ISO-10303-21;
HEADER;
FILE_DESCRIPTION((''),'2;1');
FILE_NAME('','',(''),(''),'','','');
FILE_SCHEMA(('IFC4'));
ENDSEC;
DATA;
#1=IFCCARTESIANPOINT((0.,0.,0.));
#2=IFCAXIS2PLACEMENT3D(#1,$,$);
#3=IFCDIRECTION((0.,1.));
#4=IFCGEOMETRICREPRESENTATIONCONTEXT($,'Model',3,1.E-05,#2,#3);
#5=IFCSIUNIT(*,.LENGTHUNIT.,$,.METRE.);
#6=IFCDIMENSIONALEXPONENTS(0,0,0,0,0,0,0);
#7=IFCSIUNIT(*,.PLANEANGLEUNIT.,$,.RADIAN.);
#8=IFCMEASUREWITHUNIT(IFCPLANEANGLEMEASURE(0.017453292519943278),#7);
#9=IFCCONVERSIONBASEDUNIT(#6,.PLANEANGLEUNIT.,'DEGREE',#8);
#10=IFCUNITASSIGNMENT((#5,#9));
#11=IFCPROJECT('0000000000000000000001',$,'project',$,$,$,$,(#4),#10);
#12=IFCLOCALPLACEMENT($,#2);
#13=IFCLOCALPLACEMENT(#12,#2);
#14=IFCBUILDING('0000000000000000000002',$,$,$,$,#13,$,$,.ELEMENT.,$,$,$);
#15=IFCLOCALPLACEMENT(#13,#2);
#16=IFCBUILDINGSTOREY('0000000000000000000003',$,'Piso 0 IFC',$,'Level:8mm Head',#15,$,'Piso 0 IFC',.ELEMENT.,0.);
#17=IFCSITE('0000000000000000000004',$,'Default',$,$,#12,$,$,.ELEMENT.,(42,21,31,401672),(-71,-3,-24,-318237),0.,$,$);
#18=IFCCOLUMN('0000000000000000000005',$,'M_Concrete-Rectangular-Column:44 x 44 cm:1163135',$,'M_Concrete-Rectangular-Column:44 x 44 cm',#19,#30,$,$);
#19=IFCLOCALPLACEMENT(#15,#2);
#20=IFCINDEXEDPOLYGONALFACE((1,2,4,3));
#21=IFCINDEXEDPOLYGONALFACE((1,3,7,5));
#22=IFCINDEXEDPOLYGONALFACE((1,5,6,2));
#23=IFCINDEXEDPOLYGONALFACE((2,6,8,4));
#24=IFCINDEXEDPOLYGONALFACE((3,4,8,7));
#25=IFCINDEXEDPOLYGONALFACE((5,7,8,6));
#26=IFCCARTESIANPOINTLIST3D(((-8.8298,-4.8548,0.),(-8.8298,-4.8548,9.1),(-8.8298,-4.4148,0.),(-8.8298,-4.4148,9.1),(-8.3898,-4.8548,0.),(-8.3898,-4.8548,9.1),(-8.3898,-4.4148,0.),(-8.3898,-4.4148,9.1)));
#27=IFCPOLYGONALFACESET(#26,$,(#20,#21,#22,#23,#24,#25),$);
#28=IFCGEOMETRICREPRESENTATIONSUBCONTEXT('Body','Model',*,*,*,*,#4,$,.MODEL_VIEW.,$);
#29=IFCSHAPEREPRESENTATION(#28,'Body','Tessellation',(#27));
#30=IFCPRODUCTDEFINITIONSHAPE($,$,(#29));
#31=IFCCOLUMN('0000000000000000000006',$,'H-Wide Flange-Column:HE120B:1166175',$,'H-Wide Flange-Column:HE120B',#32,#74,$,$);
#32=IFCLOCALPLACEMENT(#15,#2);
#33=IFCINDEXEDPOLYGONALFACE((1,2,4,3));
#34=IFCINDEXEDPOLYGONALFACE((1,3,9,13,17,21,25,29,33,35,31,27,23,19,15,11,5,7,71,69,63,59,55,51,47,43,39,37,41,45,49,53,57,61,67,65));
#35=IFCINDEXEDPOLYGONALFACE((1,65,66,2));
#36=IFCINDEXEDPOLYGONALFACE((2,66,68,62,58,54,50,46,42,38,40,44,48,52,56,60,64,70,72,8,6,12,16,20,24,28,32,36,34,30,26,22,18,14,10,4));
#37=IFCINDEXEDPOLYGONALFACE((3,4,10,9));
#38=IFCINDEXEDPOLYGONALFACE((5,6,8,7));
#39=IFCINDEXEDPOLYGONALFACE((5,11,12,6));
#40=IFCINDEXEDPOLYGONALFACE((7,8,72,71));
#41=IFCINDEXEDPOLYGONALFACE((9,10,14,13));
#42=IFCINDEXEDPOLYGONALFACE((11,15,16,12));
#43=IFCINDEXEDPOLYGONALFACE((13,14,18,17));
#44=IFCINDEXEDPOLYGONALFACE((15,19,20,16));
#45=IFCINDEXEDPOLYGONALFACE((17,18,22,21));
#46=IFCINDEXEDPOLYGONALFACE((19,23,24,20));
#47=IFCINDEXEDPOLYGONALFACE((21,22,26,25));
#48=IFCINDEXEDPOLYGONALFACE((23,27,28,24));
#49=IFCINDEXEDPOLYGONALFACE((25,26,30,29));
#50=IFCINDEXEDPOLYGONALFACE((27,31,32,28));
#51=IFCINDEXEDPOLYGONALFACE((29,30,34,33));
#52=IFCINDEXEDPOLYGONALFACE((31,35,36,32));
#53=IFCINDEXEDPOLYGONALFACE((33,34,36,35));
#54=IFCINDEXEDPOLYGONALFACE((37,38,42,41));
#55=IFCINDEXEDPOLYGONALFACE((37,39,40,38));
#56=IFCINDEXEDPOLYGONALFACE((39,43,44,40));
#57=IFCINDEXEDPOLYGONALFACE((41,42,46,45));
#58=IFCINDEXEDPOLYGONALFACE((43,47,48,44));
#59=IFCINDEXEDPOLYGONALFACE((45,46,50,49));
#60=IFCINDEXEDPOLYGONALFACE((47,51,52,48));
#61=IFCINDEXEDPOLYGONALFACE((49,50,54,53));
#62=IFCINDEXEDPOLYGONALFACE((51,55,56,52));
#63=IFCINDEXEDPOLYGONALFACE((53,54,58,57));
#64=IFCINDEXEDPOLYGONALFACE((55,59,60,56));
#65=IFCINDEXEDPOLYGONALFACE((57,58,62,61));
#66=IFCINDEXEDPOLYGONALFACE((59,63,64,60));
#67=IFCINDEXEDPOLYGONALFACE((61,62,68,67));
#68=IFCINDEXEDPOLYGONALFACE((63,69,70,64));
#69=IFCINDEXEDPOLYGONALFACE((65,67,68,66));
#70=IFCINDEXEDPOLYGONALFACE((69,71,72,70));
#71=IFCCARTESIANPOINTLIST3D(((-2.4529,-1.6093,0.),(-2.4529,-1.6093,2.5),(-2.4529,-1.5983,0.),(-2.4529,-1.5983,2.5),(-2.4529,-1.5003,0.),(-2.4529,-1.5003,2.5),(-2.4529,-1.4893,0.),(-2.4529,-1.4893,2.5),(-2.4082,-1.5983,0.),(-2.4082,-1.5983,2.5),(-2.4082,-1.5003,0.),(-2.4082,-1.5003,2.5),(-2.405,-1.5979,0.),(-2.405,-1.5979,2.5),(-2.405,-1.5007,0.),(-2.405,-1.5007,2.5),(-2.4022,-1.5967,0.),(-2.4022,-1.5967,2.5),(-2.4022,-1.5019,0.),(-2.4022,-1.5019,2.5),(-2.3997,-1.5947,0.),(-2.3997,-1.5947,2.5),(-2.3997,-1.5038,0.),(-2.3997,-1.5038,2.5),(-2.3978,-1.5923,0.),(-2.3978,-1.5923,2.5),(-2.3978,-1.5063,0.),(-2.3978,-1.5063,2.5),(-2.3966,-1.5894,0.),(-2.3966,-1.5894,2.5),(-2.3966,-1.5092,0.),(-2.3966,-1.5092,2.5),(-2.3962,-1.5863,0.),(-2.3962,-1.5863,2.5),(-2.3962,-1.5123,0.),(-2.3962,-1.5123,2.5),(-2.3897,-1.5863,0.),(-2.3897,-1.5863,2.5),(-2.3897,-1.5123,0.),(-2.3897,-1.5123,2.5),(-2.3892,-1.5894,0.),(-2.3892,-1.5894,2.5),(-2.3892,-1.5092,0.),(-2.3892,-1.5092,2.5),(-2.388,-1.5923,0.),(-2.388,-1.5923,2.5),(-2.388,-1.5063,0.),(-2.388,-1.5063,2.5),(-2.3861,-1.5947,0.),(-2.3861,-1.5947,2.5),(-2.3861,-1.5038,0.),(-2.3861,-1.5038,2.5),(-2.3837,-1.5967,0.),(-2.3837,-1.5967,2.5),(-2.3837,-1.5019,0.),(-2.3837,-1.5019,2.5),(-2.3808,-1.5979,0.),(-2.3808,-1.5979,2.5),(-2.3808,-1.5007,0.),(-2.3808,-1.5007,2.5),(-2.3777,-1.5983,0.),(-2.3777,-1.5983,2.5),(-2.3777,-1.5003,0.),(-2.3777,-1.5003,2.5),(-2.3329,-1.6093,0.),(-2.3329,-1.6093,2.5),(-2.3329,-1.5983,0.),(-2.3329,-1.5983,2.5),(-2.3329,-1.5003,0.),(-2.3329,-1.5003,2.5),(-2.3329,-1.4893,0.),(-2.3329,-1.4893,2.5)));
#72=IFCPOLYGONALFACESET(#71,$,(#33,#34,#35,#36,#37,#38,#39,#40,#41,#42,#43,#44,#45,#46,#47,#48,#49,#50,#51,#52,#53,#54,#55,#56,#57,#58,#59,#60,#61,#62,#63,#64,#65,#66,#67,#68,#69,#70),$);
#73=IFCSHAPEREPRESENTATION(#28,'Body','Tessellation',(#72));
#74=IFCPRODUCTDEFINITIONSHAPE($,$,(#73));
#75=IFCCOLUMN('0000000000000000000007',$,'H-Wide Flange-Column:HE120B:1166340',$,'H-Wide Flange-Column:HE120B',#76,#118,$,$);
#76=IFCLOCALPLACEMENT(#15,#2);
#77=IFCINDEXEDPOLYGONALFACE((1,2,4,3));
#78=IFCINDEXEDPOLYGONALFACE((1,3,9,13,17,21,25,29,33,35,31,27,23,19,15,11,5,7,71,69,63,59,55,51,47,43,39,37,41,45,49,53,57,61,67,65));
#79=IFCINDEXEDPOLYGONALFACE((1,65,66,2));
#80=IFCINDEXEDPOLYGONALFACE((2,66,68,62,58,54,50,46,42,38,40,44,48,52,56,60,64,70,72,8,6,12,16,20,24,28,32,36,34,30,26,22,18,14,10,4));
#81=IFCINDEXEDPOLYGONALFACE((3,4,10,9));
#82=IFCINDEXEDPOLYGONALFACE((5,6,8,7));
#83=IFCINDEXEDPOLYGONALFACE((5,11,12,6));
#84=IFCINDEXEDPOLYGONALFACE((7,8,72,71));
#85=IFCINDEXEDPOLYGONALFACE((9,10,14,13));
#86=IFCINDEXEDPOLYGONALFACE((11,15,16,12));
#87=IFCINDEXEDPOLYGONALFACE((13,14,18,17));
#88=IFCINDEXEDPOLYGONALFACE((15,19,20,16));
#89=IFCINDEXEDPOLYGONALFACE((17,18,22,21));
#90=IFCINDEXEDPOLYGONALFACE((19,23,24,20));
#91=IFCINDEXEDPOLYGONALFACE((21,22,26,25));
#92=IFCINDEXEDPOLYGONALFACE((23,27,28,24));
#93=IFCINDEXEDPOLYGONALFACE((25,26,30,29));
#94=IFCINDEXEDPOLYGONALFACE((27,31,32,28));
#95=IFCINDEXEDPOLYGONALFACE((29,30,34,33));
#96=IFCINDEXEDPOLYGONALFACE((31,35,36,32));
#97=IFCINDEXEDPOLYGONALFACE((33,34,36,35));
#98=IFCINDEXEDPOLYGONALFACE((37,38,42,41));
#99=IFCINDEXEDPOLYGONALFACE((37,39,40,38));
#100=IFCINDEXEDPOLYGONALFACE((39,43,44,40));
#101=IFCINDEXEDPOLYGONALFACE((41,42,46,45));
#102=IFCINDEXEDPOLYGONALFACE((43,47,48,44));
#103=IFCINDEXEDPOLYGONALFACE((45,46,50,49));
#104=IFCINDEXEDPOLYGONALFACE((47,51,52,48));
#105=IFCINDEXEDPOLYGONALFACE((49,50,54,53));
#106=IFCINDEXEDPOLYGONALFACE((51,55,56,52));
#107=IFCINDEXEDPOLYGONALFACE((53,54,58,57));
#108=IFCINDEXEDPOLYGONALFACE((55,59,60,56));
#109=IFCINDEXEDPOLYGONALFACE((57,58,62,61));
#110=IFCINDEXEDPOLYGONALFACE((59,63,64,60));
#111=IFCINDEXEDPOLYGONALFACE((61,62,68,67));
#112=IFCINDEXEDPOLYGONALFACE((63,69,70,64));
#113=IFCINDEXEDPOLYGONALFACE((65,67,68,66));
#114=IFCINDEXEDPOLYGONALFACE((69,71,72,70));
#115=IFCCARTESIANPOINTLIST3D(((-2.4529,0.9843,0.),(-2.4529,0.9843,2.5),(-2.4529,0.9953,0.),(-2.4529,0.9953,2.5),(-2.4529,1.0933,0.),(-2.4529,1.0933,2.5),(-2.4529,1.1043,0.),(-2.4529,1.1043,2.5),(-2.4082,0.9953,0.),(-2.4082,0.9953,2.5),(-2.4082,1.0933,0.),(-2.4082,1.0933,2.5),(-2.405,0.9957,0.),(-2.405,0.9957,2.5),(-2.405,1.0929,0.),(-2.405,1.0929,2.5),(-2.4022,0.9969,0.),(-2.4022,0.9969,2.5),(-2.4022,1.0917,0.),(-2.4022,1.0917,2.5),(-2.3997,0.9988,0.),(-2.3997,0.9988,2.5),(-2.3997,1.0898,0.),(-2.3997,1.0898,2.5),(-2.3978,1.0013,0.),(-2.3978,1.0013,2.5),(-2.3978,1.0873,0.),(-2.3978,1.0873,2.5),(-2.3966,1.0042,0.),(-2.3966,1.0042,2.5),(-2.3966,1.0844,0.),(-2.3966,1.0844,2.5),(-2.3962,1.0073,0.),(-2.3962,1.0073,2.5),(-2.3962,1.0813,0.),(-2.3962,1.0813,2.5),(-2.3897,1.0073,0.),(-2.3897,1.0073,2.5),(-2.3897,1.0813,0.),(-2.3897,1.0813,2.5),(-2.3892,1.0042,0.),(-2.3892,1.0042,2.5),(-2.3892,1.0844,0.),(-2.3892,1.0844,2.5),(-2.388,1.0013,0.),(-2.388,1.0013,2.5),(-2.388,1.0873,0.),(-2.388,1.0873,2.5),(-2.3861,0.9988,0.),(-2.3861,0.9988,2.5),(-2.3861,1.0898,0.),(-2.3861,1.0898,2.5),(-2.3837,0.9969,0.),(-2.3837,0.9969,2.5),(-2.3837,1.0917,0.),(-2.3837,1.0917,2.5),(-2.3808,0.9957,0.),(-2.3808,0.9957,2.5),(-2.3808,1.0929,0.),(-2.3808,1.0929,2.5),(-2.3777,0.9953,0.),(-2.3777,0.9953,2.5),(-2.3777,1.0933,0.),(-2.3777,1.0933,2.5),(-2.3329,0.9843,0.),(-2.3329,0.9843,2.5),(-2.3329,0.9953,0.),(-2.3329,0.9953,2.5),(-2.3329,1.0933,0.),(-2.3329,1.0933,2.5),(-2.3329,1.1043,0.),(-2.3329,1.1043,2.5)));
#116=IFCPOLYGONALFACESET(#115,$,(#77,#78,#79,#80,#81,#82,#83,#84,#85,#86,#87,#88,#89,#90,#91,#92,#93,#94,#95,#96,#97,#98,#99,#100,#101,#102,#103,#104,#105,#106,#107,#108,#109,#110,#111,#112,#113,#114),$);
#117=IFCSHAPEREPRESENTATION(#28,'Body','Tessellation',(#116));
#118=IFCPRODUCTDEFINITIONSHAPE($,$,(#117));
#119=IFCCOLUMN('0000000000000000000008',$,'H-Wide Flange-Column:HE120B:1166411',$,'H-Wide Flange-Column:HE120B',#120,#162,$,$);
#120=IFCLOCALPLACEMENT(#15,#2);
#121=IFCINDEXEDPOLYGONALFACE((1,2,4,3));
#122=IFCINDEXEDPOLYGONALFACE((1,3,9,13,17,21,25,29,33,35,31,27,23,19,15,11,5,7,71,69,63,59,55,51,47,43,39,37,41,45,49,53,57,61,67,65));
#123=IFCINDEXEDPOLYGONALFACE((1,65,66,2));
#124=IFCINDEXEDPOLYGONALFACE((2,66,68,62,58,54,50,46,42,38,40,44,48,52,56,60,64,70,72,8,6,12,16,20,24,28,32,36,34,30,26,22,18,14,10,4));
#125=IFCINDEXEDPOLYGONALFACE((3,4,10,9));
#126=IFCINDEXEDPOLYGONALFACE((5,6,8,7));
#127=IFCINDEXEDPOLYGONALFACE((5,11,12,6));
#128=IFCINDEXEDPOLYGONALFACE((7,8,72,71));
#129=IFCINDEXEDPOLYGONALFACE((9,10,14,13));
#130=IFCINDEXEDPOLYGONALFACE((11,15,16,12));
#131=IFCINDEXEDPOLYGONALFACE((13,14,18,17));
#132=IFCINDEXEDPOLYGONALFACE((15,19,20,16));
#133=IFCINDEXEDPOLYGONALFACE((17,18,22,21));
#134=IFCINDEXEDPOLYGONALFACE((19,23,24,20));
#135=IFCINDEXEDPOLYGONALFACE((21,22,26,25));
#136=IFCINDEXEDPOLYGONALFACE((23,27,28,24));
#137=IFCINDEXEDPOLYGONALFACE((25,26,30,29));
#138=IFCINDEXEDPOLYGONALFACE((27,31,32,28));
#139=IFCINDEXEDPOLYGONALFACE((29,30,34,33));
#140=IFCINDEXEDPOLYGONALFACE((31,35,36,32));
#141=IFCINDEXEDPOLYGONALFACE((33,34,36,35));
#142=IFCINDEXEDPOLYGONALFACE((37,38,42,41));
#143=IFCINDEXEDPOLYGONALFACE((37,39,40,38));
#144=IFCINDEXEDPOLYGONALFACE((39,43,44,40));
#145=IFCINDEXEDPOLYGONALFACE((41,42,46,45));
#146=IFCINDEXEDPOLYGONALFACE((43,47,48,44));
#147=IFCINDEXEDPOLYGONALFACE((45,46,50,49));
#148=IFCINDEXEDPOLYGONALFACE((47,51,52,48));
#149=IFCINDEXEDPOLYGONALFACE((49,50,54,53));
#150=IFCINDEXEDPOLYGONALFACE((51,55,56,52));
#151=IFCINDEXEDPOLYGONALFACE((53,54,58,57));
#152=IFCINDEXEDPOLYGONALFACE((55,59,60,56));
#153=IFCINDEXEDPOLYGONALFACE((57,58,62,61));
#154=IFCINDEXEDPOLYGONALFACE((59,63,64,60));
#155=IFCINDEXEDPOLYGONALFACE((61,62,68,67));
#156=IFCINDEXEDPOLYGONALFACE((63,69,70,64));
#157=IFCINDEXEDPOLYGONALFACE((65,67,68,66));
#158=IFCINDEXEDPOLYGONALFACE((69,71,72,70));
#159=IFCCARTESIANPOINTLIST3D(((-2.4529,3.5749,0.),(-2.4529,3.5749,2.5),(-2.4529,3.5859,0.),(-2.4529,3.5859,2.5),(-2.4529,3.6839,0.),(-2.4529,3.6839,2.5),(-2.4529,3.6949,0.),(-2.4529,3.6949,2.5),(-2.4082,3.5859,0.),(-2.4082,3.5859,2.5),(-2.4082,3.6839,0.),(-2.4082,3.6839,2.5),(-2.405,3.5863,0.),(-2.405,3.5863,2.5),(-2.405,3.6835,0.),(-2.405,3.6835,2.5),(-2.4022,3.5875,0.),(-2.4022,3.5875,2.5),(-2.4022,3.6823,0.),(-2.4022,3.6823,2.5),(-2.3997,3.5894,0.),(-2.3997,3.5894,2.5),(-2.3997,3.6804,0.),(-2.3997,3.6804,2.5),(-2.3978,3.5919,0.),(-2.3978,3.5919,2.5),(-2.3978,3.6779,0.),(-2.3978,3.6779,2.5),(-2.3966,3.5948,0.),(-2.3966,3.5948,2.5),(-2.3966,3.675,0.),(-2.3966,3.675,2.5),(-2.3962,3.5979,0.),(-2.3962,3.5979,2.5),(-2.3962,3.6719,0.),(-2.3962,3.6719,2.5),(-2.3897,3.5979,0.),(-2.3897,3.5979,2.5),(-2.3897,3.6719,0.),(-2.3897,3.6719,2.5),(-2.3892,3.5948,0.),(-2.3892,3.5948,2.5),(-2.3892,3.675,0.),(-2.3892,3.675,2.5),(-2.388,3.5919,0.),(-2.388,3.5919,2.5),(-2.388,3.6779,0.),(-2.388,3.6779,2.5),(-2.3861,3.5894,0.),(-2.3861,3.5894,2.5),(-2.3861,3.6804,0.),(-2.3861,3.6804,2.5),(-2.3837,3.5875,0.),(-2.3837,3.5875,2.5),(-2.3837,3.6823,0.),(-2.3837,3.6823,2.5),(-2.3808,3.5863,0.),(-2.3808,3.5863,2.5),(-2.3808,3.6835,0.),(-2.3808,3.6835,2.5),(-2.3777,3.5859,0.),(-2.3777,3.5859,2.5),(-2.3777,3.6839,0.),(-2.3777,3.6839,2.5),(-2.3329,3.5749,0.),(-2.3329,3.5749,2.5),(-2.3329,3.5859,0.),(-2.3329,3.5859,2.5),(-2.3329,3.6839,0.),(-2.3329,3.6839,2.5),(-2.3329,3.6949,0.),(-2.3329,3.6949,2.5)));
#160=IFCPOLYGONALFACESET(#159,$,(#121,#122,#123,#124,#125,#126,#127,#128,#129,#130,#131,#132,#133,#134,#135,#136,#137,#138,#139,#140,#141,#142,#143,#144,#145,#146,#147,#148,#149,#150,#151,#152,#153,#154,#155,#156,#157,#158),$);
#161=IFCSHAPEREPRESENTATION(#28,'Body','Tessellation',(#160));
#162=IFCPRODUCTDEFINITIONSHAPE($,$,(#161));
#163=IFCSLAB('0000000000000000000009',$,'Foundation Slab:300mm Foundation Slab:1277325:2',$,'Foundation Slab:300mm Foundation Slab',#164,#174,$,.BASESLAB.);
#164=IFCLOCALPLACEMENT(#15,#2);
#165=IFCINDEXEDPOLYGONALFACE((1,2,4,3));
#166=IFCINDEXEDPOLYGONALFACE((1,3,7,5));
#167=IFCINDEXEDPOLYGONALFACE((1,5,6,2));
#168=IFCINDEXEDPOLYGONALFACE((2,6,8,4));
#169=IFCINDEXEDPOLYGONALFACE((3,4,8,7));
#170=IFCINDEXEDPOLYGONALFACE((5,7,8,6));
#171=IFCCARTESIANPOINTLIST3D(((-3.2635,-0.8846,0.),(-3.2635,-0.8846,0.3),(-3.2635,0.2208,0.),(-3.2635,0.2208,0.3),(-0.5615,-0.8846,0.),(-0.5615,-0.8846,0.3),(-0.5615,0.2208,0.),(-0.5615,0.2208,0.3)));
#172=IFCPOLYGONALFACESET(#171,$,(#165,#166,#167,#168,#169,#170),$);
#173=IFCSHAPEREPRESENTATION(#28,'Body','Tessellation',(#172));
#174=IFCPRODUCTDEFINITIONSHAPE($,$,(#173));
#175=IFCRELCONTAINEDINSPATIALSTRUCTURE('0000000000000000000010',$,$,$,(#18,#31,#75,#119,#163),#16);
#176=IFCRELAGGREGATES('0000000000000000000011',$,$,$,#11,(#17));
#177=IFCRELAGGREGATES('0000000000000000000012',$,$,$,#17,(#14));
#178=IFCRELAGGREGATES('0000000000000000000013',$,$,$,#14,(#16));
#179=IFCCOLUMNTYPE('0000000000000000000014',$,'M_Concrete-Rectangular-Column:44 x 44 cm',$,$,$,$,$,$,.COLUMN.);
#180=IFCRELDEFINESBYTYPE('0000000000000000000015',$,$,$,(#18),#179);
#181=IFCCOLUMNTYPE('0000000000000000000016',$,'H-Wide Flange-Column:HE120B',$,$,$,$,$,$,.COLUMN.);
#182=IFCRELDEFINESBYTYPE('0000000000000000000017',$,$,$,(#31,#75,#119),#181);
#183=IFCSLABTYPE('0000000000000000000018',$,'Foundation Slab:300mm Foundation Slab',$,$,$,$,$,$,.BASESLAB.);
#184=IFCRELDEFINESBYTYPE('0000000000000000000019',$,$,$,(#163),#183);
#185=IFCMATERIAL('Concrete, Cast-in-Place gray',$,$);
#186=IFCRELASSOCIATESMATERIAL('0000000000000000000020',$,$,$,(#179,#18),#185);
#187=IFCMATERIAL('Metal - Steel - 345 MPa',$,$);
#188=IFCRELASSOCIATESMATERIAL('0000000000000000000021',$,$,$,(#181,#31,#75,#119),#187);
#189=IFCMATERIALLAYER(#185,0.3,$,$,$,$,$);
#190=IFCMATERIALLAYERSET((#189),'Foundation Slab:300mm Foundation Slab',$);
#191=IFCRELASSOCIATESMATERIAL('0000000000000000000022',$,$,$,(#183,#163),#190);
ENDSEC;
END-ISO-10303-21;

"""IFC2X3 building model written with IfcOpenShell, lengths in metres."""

from ifc_helpers import new_model, entity, si_unit, converted_unit, direction, frame, frame_2d, origin, origin_2d_with_axis, place, context, subcontext, project, spatial, rectangle, i_section, extrude, source, transform, mapped, material, layer, layer_set, layer_usage, type_object, type_shapes, element, save


model = new_model("IFC2X3")

# Units and contexts
model_context = context("Model", 3, precision=1e-05, world=origin(), true_north=direction((0.0, 1.0)))
body_context = subcontext(model_context, "Body", "Model", "MODEL_VIEW")
ifc_project = project(units=[si_unit("LENGTHUNIT", "METRE"), converted_unit("PLANEANGLEUNIT", "DEGREE", entity("IfcPlaneAngleMeasure", 0.017453292519943278), si_unit("PLANEANGLEUNIT", "RADIAN"), dimensions=[0, 0, 0, 0, 0, 0, 0])], contexts=[model_context])

# Site, building, storey
site_placement = place(None, origin())
site = spatial("IfcSite", under=ifc_project, at=site_placement, Name="Default", CompositionType="ELEMENT", RefLatitude=(42, 21, 31, 401672), RefLongitude=(-71, -3, -24, -318237), RefElevation=0.0)
building_placement = place(site_placement, origin())
building = spatial("IfcBuilding", under=site, at=building_placement, CompositionType="ELEMENT")
storey_placement = place(building_placement, origin())
storey = spatial("IfcBuildingStorey", under=building, at=storey_placement, Name="Piso 0 IFC", ObjectType="Level:8mm Head", LongName="Piso 0 IFC", CompositionType="ELEMENT", Elevation=0.0)

# Columns
ifc_material_1 = material(Name="Concrete, Cast-in-Place gray")
column_type_1 = type_object("IfcColumnType", Name="M_Concrete-Rectangular-Column:44 x 44 cm", PredefinedType="COLUMN", material=ifc_material_1)
shared_shape_1 = source(origin(), body_context, "Body", "SweptSolid", [
    extrude(rectangle(XDim=0.44, YDim=0.44, at=origin_2d_with_axis()), frame((-8.6098, -4.6348, 0.0), z_axis=(0.0, 0.0, 1.0), x_axis=(-1.0, 0.0, 0.0)), (0.0, 0.0, 1.0), 9.1),
])
type_shapes(column_type_1, [shared_shape_1])
column_1_placement = place(storey_placement, origin())
element("IfcColumn", 1, at=column_1_placement, inside=storey, type_object=column_type_1, material=ifc_material_1, Name="M_Concrete-Rectangular-Column:44 x 44 cm:1163135", ObjectType="M_Concrete-Rectangular-Column:44 x 44 cm", context=body_context, shape_type="MappedRepresentation", body=[
    mapped(shared_shape_1, transform((0.0, 0.0, 0.0), scale=1.0)),
])
ifc_material_2 = material(Name="Metal - Steel - 345 MPa")
column_type_2 = type_object("IfcColumnType", Name="H-Wide Flange-Column:HE120B", PredefinedType="COLUMN", material=ifc_material_2)
shared_shape_2 = source(origin(), body_context, "Body", "SweptSolid", [
    extrude(i_section(OverallWidth=0.12, OverallDepth=0.12, WebThickness=0.0065, FlangeThickness=0.011, FilletRadius=0.012, at=frame_2d((0.0, 0.0), x_axis=(1.0, 0.0))), frame((0.0, 0.0, 0.0), z_axis=(0.0, 0.0, 1.0), x_axis=(-1.0, 0.0, 0.0)), (0.0, 0.0, 1.0), 2.5),
])
type_shapes(column_type_2, [shared_shape_2])
for number, where, name in (
    (2, (-2.3929, -1.5493, 0.0), "H-Wide Flange-Column:HE120B:1166175"),
    (3, (-2.3929, 1.0443, 0.0), "H-Wide Flange-Column:HE120B:1166340"),
    (4, (-2.3929, 3.6349, 0.0), "H-Wide Flange-Column:HE120B:1166411"),
):
    element("IfcColumn", number, at=place(storey_placement, frame(where)), inside=storey, type_object=column_type_2, material=ifc_material_2, Name=name, ObjectType="H-Wide Flange-Column:HE120B", context=body_context, shape_type="MappedRepresentation", body=[
        mapped(shared_shape_2, transform((0.0, 0.0, 0.0), scale=1.0)),
    ])

# Slab
ifc_layer = layer(ifc_material_1, 0.3)
ifc_layer_set = layer_set([ifc_layer], Name="Foundation Slab:300mm Foundation Slab")
ifc_layer_usage = layer_usage(ifc_layer_set, "AXIS3", "POSITIVE", 0.0)
slab_type = type_object("IfcSlabType", Name="Foundation Slab:300mm Foundation Slab", PredefinedType="BASESLAB", material=ifc_layer_set)
slab_1_placement = place(storey_placement, frame((-3.2635, -0.8846, 0.0)))
element("IfcSlab", 5, at=slab_1_placement, inside=storey, type_object=slab_type, material=ifc_layer_usage, Name="Foundation Slab:300mm Foundation Slab:1277325:2", ObjectType="Foundation Slab:300mm Foundation Slab", PredefinedType="BASESLAB", context=body_context, shape_type="SweptSolid", body=[
    extrude(rectangle(XDim=1.1054, YDim=2.702, at=frame_2d((0.0, -1.4235), x_axis=(0.0, -1.0))), frame((1.351, 1.9762, 0.3), z_axis=(0.0, 0.0, -1.0), x_axis=(-1.0, 0.0, 0.0)), (0.0, 0.0, 1.0), 0.3),
])

save(model, "model.ifc")
